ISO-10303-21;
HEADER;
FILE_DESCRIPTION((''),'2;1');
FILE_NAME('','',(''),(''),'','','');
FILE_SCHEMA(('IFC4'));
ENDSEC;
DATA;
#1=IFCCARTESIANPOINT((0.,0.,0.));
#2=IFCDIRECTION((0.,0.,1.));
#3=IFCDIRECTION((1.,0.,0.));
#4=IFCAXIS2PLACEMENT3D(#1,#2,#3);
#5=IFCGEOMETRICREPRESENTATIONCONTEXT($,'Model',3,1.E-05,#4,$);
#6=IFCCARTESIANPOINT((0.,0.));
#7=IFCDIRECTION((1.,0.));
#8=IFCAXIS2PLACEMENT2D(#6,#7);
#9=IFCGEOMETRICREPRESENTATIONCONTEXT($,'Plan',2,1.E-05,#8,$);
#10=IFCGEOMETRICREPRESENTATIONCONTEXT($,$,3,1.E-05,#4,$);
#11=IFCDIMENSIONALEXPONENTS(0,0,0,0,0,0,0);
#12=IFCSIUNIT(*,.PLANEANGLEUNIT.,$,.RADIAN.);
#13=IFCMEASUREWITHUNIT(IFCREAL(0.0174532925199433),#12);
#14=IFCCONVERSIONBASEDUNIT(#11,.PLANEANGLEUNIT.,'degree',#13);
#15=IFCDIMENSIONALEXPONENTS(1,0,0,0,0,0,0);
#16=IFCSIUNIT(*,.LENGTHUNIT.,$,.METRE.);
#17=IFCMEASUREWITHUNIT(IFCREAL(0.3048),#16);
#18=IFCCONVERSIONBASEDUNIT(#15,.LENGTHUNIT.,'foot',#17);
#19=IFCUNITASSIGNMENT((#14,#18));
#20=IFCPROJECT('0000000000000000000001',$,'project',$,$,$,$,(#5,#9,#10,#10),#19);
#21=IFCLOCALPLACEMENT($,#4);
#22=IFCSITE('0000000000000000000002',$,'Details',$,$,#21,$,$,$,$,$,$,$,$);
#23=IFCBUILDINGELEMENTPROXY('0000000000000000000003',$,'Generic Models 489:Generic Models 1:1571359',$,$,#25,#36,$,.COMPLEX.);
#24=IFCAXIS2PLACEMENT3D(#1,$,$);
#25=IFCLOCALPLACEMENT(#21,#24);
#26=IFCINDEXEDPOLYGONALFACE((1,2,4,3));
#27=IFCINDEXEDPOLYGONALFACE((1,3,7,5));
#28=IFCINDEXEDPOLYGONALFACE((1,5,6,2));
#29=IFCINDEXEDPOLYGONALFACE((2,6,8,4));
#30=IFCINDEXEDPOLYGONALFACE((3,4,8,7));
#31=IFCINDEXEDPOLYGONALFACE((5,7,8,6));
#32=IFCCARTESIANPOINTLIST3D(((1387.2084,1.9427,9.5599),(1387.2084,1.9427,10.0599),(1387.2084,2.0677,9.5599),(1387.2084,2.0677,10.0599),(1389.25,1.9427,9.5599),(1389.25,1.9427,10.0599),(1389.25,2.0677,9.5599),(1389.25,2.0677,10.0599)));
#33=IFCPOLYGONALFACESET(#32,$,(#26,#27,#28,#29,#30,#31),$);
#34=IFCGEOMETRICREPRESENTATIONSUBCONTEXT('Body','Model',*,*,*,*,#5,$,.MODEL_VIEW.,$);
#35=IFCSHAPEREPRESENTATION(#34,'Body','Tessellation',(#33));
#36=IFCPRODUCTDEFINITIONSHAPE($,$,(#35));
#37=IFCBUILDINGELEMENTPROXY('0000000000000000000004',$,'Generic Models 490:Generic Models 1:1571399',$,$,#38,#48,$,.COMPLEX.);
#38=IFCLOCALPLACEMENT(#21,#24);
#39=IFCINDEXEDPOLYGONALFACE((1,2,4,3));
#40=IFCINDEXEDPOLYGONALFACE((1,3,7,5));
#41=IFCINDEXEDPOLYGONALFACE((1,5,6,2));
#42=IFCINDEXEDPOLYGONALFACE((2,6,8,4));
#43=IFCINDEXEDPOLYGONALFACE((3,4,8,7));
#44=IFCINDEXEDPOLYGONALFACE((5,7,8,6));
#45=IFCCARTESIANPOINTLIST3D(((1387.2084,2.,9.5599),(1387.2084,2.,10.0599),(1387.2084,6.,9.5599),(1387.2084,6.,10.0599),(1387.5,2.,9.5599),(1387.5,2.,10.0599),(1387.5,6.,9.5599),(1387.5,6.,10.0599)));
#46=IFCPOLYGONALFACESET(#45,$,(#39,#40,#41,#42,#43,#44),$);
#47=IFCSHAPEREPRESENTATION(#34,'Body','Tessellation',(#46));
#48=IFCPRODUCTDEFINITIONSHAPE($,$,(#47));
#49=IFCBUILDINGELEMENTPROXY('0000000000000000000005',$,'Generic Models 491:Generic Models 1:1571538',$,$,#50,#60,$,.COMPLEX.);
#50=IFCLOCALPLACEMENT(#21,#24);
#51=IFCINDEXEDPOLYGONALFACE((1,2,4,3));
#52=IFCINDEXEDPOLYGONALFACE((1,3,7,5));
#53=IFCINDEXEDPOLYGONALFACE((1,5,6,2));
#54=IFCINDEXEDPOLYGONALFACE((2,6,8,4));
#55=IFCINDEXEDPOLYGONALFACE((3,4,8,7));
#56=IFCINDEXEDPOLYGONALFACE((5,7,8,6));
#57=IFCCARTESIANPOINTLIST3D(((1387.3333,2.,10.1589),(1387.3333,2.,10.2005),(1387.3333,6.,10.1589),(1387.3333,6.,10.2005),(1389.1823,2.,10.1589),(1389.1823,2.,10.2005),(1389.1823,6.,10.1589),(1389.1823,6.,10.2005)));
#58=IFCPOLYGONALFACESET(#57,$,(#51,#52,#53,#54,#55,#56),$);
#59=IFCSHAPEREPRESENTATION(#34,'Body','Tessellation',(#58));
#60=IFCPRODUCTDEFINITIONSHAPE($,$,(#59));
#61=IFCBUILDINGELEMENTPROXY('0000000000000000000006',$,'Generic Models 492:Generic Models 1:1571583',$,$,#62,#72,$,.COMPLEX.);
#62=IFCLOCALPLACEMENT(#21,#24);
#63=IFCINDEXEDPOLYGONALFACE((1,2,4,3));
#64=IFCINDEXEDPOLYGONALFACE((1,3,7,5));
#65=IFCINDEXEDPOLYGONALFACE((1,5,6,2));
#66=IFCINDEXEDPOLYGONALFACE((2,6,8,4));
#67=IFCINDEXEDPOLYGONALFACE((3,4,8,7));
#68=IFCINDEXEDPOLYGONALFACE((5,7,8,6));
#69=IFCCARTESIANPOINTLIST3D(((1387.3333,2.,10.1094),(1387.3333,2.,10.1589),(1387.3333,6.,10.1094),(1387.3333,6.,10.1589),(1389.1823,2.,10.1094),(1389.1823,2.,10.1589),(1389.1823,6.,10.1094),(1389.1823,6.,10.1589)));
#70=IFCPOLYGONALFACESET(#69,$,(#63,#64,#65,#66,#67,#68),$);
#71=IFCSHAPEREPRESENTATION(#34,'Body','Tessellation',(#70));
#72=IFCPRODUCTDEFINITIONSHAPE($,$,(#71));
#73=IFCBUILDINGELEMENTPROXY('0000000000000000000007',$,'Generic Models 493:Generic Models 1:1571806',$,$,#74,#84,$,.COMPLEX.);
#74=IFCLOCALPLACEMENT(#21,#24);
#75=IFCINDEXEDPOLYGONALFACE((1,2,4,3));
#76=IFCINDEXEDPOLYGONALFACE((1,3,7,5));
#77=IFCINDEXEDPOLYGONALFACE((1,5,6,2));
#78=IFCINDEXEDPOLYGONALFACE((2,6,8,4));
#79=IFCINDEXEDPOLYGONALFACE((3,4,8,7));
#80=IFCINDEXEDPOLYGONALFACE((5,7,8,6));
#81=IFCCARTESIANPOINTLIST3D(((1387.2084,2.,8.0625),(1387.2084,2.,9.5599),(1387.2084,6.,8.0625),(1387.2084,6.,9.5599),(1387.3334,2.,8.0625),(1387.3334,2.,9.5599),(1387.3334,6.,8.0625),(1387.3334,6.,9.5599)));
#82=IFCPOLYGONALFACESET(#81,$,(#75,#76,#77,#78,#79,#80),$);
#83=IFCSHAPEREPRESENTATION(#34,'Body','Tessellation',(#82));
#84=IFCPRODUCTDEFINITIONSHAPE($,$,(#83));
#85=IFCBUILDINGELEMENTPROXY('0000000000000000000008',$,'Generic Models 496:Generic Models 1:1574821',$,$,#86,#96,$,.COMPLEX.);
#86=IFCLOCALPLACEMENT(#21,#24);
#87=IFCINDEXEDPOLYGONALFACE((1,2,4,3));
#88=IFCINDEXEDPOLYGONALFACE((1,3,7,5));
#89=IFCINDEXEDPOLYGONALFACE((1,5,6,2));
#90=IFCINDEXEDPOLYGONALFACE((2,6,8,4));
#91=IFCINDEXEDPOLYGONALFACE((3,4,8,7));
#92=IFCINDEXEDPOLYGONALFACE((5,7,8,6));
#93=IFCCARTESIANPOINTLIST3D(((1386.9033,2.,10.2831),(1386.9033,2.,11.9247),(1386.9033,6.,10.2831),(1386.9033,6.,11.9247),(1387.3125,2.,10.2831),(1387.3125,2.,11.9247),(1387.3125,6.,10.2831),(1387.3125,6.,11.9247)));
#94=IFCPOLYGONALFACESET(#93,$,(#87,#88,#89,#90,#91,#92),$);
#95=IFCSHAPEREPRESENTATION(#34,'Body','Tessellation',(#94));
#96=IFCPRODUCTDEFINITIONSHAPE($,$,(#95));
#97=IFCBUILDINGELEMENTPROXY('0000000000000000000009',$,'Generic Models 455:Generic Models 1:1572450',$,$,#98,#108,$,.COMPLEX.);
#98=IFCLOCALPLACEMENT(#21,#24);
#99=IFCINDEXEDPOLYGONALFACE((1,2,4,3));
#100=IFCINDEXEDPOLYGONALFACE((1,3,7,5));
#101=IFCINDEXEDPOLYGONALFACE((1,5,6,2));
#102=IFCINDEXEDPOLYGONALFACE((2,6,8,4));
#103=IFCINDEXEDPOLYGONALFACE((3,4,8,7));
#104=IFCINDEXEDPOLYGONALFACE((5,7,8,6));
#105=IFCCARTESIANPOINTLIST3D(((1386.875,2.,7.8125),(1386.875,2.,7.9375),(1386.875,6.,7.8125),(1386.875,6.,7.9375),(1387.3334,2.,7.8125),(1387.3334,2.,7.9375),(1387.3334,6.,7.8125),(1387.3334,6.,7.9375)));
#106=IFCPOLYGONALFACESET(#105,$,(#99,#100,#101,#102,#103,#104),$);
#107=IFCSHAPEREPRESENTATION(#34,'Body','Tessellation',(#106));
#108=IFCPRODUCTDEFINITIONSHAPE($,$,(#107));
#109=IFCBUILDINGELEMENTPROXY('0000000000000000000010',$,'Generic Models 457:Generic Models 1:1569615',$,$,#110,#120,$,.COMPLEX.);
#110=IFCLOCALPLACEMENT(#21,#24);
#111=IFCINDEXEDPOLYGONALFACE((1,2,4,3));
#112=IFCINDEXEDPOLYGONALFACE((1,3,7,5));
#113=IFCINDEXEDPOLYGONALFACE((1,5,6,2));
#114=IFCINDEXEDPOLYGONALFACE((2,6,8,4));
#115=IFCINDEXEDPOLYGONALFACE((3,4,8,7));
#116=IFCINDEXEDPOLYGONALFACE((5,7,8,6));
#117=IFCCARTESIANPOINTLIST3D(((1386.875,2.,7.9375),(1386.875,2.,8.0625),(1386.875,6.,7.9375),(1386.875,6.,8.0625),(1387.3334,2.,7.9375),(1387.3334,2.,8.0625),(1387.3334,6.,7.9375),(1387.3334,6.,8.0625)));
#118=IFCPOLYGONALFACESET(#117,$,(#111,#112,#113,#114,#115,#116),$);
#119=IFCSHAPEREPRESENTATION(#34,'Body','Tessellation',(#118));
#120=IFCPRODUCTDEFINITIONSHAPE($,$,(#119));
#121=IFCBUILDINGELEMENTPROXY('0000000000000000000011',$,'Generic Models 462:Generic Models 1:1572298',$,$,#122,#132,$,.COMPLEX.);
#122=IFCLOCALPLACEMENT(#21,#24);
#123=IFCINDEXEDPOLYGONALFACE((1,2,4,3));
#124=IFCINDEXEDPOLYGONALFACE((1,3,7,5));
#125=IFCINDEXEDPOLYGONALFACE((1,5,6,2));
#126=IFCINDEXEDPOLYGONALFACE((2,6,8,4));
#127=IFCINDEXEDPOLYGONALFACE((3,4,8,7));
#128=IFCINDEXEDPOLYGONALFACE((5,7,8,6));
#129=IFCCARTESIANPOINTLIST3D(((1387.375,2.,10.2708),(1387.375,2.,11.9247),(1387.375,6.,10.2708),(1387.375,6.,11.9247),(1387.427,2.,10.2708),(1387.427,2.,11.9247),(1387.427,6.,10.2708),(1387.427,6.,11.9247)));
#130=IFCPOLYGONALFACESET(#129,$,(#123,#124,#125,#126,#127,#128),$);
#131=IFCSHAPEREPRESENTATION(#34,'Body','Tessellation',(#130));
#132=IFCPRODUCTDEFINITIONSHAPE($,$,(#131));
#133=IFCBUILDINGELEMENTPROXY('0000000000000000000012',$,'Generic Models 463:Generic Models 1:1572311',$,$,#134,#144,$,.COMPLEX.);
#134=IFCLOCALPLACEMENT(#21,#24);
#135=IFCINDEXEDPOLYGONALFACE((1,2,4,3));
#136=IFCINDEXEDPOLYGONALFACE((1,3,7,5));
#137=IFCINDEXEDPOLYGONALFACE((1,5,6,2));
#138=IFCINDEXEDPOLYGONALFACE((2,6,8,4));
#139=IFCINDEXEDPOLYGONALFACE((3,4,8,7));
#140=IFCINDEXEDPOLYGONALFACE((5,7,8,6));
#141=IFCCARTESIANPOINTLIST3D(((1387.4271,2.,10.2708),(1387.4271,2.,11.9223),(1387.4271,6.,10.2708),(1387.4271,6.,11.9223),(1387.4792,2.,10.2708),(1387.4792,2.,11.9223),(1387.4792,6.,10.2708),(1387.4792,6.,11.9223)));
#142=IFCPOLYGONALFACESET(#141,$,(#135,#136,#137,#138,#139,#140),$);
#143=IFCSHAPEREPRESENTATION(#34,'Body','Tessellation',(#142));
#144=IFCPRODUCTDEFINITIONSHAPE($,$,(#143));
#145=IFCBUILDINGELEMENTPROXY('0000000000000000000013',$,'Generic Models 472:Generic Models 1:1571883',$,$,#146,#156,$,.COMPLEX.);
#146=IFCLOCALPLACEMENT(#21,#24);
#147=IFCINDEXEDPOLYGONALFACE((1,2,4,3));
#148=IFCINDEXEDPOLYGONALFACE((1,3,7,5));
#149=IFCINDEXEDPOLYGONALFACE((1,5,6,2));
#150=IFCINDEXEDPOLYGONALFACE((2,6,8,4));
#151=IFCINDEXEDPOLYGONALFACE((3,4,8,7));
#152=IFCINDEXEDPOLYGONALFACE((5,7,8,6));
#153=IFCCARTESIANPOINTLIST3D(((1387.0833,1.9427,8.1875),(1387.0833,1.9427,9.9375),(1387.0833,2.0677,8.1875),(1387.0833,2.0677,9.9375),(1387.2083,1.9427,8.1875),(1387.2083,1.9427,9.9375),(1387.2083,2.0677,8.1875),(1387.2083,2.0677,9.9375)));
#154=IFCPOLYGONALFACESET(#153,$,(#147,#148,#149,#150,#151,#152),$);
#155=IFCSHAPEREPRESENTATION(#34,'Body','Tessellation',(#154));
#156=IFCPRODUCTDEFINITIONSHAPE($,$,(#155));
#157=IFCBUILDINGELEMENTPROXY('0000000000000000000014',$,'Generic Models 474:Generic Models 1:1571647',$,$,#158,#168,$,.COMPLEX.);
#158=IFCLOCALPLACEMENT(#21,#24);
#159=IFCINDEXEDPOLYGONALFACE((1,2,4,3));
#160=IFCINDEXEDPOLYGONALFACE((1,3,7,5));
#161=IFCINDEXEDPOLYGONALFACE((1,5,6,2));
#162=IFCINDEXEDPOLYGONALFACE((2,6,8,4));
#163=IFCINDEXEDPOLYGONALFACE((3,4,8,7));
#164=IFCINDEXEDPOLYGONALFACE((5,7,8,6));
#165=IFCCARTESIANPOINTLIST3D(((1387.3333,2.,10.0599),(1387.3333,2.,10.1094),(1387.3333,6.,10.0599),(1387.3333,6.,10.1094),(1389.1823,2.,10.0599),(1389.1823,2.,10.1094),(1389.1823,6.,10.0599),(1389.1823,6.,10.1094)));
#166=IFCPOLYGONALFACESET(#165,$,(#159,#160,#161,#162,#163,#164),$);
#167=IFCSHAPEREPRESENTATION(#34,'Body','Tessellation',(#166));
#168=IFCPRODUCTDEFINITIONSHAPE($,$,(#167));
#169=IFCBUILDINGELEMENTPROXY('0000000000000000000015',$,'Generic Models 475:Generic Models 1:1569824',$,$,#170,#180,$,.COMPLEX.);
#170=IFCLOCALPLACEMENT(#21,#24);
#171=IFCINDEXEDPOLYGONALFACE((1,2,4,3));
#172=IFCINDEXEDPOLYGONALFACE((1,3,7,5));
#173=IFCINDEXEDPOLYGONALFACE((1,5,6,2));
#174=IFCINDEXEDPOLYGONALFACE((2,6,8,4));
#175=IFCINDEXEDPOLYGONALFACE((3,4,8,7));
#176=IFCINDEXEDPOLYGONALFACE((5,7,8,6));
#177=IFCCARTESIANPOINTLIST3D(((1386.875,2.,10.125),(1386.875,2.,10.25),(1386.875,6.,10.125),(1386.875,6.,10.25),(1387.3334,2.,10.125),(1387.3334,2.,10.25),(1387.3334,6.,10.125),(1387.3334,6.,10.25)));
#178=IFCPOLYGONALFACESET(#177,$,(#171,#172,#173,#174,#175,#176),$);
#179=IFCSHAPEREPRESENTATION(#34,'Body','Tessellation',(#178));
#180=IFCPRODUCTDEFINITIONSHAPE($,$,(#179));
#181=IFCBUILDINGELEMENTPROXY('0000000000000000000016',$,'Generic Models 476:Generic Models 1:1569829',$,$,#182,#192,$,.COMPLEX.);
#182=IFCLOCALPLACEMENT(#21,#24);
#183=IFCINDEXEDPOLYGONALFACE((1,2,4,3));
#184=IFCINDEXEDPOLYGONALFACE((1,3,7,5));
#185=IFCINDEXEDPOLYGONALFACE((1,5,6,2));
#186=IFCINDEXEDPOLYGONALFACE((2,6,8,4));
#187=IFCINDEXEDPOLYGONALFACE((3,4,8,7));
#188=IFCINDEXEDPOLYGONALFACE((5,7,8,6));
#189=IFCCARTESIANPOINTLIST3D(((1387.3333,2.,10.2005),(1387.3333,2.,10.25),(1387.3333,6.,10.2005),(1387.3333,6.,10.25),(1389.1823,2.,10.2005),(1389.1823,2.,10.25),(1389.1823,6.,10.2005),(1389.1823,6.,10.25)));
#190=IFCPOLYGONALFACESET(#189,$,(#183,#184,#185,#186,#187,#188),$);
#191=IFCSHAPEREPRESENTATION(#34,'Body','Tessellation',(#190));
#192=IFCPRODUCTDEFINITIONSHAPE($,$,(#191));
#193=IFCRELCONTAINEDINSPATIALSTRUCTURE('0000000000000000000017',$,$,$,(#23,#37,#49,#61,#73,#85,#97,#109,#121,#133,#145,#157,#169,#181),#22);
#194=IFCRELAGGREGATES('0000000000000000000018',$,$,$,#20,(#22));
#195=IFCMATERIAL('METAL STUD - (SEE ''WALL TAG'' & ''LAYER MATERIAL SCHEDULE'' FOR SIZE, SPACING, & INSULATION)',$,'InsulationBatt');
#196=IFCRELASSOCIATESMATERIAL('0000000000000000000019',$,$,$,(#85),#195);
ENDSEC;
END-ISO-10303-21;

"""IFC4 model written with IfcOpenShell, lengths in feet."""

from ifc_helpers import new_model, entity, si_unit, converted_unit, frame, origin_with_axes, origin_2d_with_axis, place, context, subcontext, project, spatial, polyline, outline, extrude, material, element, save


model = new_model("IFC4")

# Units and contexts
model_context = context("Model", 3, precision=1e-05, world=origin_with_axes())
plan_context = context("Plan", 2, precision=1e-05, world=origin_2d_with_axis())
context_of_model = context(None, 3, precision=1e-05, world=origin_with_axes())
body_context = subcontext(model_context, "Body", "Model", "MODEL_VIEW")
ifc_project = project(units=[converted_unit("PLANEANGLEUNIT", "degree", entity("IfcReal", 0.0174532925199433), si_unit("PLANEANGLEUNIT", "RADIAN"), dimensions=[0, 0, 0, 0, 0, 0, 0]), converted_unit("LENGTHUNIT", "foot", entity("IfcReal", 0.3048), si_unit("LENGTHUNIT", "METRE"), dimensions=[1, 0, 0, 0, 0, 0, 0])], contexts=[model_context, plan_context, context_of_model, context_of_model])

# Site
site_placement = place(None, origin_with_axes())
site = spatial("IfcSite", under=ifc_project, at=site_placement, Name="Details")

# Building element proxies
proxy_1_placement = place(site_placement, frame((1387.2084, 1.9427, 9.5599), z_axis=(1.0, 0.0, 0.0), x_axis=(0.0, 0.0, -1.0)))
element("IfcBuildingElementProxy", 1, at=proxy_1_placement, inside=site, Name="Generic Models 489:Generic Models 1:1571359", PredefinedType="COMPLEX", context=body_context, shape_type="SweptSolid", body=[
    extrude(outline(polyline([(-0.0625, -0.25), (0.0625, -0.25), (0.0625, 0.25), (-0.0625, 0.25), (-0.0625, -0.25)])), frame((-0.25, 0.0625, 0.0), z_axis=(0.0, 0.0, -1.0), x_axis=(0.0, -1.0, 0.0)), (0.0, 0.0, -1.0), 2.0417),
])
proxy_2_placement = place(site_placement, frame((1387.2084, 6.0, 9.5599), z_axis=(0.0, -1.0, 0.0), x_axis=(0.0, 0.0, 1.0)))
element("IfcBuildingElementProxy", 2, at=proxy_2_placement, inside=site, Name="Generic Models 490:Generic Models 1:1571399", PredefinedType="COMPLEX", context=body_context, shape_type="SweptSolid", body=[
    extrude(outline(polyline([(-0.25, -0.1458), (0.25, -0.1458), (0.25, 0.1458), (-0.25, 0.1458), (-0.25, -0.1458)])), frame((0.25, -0.1458, 0.0), z_axis=(0.0, 0.0, -1.0), x_axis=(-1.0, 0.0, 0.0)), (0.0, 0.0, -1.0), 4.0),
])
proxy_3_placement = place(site_placement, frame((1387.3333, 6.0, 10.1589), z_axis=(0.0, -1.0, 0.0), x_axis=(0.0, 0.0, 1.0)))
element("IfcBuildingElementProxy", 3, at=proxy_3_placement, inside=site, Name="Generic Models 491:Generic Models 1:1571538", PredefinedType="COMPLEX", context=body_context, shape_type="SweptSolid", body=[
    extrude(outline(polyline([(-0.0208, -0.9245), (0.0208, -0.9245), (0.0208, 0.9245), (-0.0208, 0.9245), (-0.0208, -0.9245)])), frame((0.0208, -0.9245, 0.0), z_axis=(0.0, 0.0, -1.0), x_axis=(-1.0, 0.0, 0.0)), (0.0, 0.0, -1.0), 4.0),
])
proxy_4_placement = place(site_placement, frame((1387.3333, 6.0, 10.1094), z_axis=(0.0, -1.0, 0.0), x_axis=(0.0, 0.0, 1.0)))
element("IfcBuildingElementProxy", 4, at=proxy_4_placement, inside=site, Name="Generic Models 492:Generic Models 1:1571583", PredefinedType="COMPLEX", context=body_context, shape_type="SweptSolid", body=[
    extrude(outline(polyline([(-0.0247, -0.9245), (0.0247, -0.9245), (0.0247, 0.9245), (-0.0247, 0.9245), (-0.0247, -0.9245)])), frame((0.0247, -0.9245, 0.0), z_axis=(0.0, 0.0, -1.0), x_axis=(-1.0, 0.0, 0.0)), (0.0, 0.0, -1.0), 4.0),
])
proxy_5_placement = place(site_placement, frame((1387.2084, 6.0, 8.0625), z_axis=(0.0, -1.0, 0.0), x_axis=(0.0, 0.0, 1.0)))
element("IfcBuildingElementProxy", 5, at=proxy_5_placement, inside=site, Name="Generic Models 493:Generic Models 1:1571806", PredefinedType="COMPLEX", context=body_context, shape_type="SweptSolid", body=[
    extrude(outline(polyline([(-0.7487, -0.0625), (0.7487, -0.0625), (0.7487, 0.0625), (-0.7487, 0.0625), (-0.7487, -0.0625)])), frame((0.7487, -0.0625, 0.0), z_axis=(0.0, 0.0, -1.0), x_axis=(-1.0, 0.0, 0.0)), (0.0, 0.0, -1.0), 4.0),
])
ifc_material_1 = material(Name="METAL STUD - (SEE 'WALL TAG' & 'LAYER MATERIAL SCHEDULE' FOR SIZE, SPACING, & INSULATION)", Category="InsulationBatt")
proxy_6_placement = place(site_placement, frame((1386.9033, 6.0, 10.2831), z_axis=(0.0, -1.0, 0.0), x_axis=(0.0, 0.0, 1.0)))
element("IfcBuildingElementProxy", 6, at=proxy_6_placement, inside=site, material=ifc_material_1, Name="Generic Models 496:Generic Models 1:1574821", PredefinedType="COMPLEX", context=body_context, shape_type="SweptSolid", body=[
    extrude(outline(polyline([(-0.8208, -0.2046), (0.8208, -0.2046), (0.8208, 0.2046), (-0.8208, 0.2046), (-0.8208, -0.2046)])), frame((0.8208, -0.2046, 0.0), z_axis=(0.0, 0.0, -1.0), x_axis=(1.0, 0.0, 0.0)), (0.0, 0.0, -1.0), 4.0),
])
for number, where, z_axis, x_axis, name in (
    (7, (1386.875, 6.0, 7.8125), (0.0, -1.0, 0.0), (0.0, 0.0, 1.0), "Generic Models 455:Generic Models 1:1572450"),
    (8, (1386.875, 6.0, 7.9375), (0.0, -1.0, 0.0), (0.0, 0.0, 1.0), "Generic Models 457:Generic Models 1:1569615"),
):
    element("IfcBuildingElementProxy", number, at=place(site_placement, frame(where, z_axis=z_axis, x_axis=x_axis)), inside=site, Name=name, PredefinedType="COMPLEX", context=body_context, shape_type="SweptSolid", body=[
        extrude(outline(polyline([(-0.2292, -0.0625), (0.2292, -0.0625), (0.2292, 0.0625), (-0.2292, 0.0625), (-0.2292, -0.0625)])), frame((0.0625, -0.2292, 0.0), z_axis=(0.0, 0.0, -1.0), x_axis=(0.0, 1.0, 0.0)), (0.0, 0.0, -1.0), 4.0),
    ])
proxy_7_placement = place(site_placement, frame((1387.375, 6.0, 10.2708), z_axis=(0.0, -1.0, 0.0), x_axis=(0.0, 0.0, 1.0)))
element("IfcBuildingElementProxy", 9, at=proxy_7_placement, inside=site, Name="Generic Models 462:Generic Models 1:1572298", PredefinedType="COMPLEX", context=body_context, shape_type="SweptSolid", body=[
    extrude(outline(polyline([(-0.026, -0.8269), (0.026, -0.8269), (0.026, 0.8269), (-0.026, 0.8269), (-0.026, -0.8269)])), frame((0.8269, -0.026, 0.0), z_axis=(0.0, 0.0, -1.0), x_axis=(0.0, 1.0, 0.0)), (0.0, 0.0, -1.0), 4.0),
])
proxy_8_placement = place(site_placement, frame((1387.4271, 6.0, 10.2708), z_axis=(0.0, -1.0, 0.0), x_axis=(0.0, 0.0, 1.0)))
element("IfcBuildingElementProxy", 10, at=proxy_8_placement, inside=site, Name="Generic Models 463:Generic Models 1:1572311", PredefinedType="COMPLEX", context=body_context, shape_type="SweptSolid", body=[
    extrude(outline(polyline([(-0.026, -0.8258), (0.026, -0.8258), (0.026, 0.8258), (-0.026, 0.8258), (-0.026, -0.8258)])), frame((0.8258, -0.026, 0.0), z_axis=(0.0, 0.0, -1.0), x_axis=(0.0, 1.0, 0.0)), (0.0, 0.0, -1.0), 4.0),
])
proxy_9_placement = place(site_placement, frame((1387.0833, 1.9427, 8.1875), z_axis=(0.0, 0.0, 1.0), x_axis=(0.0, 1.0, 0.0)))
element("IfcBuildingElementProxy", 11, at=proxy_9_placement, inside=site, Name="Generic Models 472:Generic Models 1:1571883", PredefinedType="COMPLEX", context=body_context, shape_type="SweptSolid", body=[
    extrude(outline(polyline([(-0.0625, -0.0625), (0.0625, -0.0625), (0.0625, 0.0625), (-0.0625, 0.0625), (-0.0625, -0.0625)])), frame((0.0625, -0.0625, 0.0), z_axis=(0.0, 0.0, -1.0), x_axis=(-1.0, 0.0, 0.0)), (0.0, 0.0, -1.0), 1.75),
])
proxy_10_placement = place(site_placement, frame((1387.3333, 6.0, 10.0599), z_axis=(0.0, -1.0, 0.0), x_axis=(0.0, 0.0, 1.0)))
element("IfcBuildingElementProxy", 12, at=proxy_10_placement, inside=site, Name="Generic Models 474:Generic Models 1:1571647", PredefinedType="COMPLEX", context=body_context, shape_type="SweptSolid", body=[
    extrude(outline(polyline([(-0.0247, -0.9245), (0.0247, -0.9245), (0.0247, 0.9245), (-0.0247, 0.9245), (-0.0247, -0.9245)])), frame((0.0247, -0.9245, 0.0), z_axis=(0.0, 0.0, -1.0), x_axis=(-1.0, 0.0, 0.0)), (0.0, 0.0, -1.0), 4.0),
])
proxy_11_placement = place(site_placement, frame((1386.875, 6.0, 10.125), z_axis=(0.0, -1.0, 0.0), x_axis=(0.0, 0.0, 1.0)))
element("IfcBuildingElementProxy", 13, at=proxy_11_placement, inside=site, Name="Generic Models 475:Generic Models 1:1569824", PredefinedType="COMPLEX", context=body_context, shape_type="SweptSolid", body=[
    extrude(outline(polyline([(-0.2292, -0.0625), (0.2292, -0.0625), (0.2292, 0.0625), (-0.2292, 0.0625), (-0.2292, -0.0625)])), frame((0.0625, -0.2292, 0.0), z_axis=(0.0, 0.0, -1.0), x_axis=(0.0, 1.0, 0.0)), (0.0, 0.0, -1.0), 4.0),
])
proxy_12_placement = place(site_placement, frame((1387.3333, 6.0, 10.2005), z_axis=(0.0, -1.0, 0.0), x_axis=(0.0, 0.0, 1.0)))
element("IfcBuildingElementProxy", 14, at=proxy_12_placement, inside=site, Name="Generic Models 476:Generic Models 1:1569829", PredefinedType="COMPLEX", context=body_context, shape_type="SweptSolid", body=[
    extrude(outline(polyline([(-0.0247, -0.9245), (0.0247, -0.9245), (0.0247, 0.9245), (-0.0247, 0.9245), (-0.0247, -0.9245)])), frame((0.0247, -0.9245, 0.0), z_axis=(0.0, 0.0, -1.0), x_axis=(-1.0, 0.0, 0.0)), (0.0, 0.0, -1.0), 4.0),
])

save(model, "model.ifc")
